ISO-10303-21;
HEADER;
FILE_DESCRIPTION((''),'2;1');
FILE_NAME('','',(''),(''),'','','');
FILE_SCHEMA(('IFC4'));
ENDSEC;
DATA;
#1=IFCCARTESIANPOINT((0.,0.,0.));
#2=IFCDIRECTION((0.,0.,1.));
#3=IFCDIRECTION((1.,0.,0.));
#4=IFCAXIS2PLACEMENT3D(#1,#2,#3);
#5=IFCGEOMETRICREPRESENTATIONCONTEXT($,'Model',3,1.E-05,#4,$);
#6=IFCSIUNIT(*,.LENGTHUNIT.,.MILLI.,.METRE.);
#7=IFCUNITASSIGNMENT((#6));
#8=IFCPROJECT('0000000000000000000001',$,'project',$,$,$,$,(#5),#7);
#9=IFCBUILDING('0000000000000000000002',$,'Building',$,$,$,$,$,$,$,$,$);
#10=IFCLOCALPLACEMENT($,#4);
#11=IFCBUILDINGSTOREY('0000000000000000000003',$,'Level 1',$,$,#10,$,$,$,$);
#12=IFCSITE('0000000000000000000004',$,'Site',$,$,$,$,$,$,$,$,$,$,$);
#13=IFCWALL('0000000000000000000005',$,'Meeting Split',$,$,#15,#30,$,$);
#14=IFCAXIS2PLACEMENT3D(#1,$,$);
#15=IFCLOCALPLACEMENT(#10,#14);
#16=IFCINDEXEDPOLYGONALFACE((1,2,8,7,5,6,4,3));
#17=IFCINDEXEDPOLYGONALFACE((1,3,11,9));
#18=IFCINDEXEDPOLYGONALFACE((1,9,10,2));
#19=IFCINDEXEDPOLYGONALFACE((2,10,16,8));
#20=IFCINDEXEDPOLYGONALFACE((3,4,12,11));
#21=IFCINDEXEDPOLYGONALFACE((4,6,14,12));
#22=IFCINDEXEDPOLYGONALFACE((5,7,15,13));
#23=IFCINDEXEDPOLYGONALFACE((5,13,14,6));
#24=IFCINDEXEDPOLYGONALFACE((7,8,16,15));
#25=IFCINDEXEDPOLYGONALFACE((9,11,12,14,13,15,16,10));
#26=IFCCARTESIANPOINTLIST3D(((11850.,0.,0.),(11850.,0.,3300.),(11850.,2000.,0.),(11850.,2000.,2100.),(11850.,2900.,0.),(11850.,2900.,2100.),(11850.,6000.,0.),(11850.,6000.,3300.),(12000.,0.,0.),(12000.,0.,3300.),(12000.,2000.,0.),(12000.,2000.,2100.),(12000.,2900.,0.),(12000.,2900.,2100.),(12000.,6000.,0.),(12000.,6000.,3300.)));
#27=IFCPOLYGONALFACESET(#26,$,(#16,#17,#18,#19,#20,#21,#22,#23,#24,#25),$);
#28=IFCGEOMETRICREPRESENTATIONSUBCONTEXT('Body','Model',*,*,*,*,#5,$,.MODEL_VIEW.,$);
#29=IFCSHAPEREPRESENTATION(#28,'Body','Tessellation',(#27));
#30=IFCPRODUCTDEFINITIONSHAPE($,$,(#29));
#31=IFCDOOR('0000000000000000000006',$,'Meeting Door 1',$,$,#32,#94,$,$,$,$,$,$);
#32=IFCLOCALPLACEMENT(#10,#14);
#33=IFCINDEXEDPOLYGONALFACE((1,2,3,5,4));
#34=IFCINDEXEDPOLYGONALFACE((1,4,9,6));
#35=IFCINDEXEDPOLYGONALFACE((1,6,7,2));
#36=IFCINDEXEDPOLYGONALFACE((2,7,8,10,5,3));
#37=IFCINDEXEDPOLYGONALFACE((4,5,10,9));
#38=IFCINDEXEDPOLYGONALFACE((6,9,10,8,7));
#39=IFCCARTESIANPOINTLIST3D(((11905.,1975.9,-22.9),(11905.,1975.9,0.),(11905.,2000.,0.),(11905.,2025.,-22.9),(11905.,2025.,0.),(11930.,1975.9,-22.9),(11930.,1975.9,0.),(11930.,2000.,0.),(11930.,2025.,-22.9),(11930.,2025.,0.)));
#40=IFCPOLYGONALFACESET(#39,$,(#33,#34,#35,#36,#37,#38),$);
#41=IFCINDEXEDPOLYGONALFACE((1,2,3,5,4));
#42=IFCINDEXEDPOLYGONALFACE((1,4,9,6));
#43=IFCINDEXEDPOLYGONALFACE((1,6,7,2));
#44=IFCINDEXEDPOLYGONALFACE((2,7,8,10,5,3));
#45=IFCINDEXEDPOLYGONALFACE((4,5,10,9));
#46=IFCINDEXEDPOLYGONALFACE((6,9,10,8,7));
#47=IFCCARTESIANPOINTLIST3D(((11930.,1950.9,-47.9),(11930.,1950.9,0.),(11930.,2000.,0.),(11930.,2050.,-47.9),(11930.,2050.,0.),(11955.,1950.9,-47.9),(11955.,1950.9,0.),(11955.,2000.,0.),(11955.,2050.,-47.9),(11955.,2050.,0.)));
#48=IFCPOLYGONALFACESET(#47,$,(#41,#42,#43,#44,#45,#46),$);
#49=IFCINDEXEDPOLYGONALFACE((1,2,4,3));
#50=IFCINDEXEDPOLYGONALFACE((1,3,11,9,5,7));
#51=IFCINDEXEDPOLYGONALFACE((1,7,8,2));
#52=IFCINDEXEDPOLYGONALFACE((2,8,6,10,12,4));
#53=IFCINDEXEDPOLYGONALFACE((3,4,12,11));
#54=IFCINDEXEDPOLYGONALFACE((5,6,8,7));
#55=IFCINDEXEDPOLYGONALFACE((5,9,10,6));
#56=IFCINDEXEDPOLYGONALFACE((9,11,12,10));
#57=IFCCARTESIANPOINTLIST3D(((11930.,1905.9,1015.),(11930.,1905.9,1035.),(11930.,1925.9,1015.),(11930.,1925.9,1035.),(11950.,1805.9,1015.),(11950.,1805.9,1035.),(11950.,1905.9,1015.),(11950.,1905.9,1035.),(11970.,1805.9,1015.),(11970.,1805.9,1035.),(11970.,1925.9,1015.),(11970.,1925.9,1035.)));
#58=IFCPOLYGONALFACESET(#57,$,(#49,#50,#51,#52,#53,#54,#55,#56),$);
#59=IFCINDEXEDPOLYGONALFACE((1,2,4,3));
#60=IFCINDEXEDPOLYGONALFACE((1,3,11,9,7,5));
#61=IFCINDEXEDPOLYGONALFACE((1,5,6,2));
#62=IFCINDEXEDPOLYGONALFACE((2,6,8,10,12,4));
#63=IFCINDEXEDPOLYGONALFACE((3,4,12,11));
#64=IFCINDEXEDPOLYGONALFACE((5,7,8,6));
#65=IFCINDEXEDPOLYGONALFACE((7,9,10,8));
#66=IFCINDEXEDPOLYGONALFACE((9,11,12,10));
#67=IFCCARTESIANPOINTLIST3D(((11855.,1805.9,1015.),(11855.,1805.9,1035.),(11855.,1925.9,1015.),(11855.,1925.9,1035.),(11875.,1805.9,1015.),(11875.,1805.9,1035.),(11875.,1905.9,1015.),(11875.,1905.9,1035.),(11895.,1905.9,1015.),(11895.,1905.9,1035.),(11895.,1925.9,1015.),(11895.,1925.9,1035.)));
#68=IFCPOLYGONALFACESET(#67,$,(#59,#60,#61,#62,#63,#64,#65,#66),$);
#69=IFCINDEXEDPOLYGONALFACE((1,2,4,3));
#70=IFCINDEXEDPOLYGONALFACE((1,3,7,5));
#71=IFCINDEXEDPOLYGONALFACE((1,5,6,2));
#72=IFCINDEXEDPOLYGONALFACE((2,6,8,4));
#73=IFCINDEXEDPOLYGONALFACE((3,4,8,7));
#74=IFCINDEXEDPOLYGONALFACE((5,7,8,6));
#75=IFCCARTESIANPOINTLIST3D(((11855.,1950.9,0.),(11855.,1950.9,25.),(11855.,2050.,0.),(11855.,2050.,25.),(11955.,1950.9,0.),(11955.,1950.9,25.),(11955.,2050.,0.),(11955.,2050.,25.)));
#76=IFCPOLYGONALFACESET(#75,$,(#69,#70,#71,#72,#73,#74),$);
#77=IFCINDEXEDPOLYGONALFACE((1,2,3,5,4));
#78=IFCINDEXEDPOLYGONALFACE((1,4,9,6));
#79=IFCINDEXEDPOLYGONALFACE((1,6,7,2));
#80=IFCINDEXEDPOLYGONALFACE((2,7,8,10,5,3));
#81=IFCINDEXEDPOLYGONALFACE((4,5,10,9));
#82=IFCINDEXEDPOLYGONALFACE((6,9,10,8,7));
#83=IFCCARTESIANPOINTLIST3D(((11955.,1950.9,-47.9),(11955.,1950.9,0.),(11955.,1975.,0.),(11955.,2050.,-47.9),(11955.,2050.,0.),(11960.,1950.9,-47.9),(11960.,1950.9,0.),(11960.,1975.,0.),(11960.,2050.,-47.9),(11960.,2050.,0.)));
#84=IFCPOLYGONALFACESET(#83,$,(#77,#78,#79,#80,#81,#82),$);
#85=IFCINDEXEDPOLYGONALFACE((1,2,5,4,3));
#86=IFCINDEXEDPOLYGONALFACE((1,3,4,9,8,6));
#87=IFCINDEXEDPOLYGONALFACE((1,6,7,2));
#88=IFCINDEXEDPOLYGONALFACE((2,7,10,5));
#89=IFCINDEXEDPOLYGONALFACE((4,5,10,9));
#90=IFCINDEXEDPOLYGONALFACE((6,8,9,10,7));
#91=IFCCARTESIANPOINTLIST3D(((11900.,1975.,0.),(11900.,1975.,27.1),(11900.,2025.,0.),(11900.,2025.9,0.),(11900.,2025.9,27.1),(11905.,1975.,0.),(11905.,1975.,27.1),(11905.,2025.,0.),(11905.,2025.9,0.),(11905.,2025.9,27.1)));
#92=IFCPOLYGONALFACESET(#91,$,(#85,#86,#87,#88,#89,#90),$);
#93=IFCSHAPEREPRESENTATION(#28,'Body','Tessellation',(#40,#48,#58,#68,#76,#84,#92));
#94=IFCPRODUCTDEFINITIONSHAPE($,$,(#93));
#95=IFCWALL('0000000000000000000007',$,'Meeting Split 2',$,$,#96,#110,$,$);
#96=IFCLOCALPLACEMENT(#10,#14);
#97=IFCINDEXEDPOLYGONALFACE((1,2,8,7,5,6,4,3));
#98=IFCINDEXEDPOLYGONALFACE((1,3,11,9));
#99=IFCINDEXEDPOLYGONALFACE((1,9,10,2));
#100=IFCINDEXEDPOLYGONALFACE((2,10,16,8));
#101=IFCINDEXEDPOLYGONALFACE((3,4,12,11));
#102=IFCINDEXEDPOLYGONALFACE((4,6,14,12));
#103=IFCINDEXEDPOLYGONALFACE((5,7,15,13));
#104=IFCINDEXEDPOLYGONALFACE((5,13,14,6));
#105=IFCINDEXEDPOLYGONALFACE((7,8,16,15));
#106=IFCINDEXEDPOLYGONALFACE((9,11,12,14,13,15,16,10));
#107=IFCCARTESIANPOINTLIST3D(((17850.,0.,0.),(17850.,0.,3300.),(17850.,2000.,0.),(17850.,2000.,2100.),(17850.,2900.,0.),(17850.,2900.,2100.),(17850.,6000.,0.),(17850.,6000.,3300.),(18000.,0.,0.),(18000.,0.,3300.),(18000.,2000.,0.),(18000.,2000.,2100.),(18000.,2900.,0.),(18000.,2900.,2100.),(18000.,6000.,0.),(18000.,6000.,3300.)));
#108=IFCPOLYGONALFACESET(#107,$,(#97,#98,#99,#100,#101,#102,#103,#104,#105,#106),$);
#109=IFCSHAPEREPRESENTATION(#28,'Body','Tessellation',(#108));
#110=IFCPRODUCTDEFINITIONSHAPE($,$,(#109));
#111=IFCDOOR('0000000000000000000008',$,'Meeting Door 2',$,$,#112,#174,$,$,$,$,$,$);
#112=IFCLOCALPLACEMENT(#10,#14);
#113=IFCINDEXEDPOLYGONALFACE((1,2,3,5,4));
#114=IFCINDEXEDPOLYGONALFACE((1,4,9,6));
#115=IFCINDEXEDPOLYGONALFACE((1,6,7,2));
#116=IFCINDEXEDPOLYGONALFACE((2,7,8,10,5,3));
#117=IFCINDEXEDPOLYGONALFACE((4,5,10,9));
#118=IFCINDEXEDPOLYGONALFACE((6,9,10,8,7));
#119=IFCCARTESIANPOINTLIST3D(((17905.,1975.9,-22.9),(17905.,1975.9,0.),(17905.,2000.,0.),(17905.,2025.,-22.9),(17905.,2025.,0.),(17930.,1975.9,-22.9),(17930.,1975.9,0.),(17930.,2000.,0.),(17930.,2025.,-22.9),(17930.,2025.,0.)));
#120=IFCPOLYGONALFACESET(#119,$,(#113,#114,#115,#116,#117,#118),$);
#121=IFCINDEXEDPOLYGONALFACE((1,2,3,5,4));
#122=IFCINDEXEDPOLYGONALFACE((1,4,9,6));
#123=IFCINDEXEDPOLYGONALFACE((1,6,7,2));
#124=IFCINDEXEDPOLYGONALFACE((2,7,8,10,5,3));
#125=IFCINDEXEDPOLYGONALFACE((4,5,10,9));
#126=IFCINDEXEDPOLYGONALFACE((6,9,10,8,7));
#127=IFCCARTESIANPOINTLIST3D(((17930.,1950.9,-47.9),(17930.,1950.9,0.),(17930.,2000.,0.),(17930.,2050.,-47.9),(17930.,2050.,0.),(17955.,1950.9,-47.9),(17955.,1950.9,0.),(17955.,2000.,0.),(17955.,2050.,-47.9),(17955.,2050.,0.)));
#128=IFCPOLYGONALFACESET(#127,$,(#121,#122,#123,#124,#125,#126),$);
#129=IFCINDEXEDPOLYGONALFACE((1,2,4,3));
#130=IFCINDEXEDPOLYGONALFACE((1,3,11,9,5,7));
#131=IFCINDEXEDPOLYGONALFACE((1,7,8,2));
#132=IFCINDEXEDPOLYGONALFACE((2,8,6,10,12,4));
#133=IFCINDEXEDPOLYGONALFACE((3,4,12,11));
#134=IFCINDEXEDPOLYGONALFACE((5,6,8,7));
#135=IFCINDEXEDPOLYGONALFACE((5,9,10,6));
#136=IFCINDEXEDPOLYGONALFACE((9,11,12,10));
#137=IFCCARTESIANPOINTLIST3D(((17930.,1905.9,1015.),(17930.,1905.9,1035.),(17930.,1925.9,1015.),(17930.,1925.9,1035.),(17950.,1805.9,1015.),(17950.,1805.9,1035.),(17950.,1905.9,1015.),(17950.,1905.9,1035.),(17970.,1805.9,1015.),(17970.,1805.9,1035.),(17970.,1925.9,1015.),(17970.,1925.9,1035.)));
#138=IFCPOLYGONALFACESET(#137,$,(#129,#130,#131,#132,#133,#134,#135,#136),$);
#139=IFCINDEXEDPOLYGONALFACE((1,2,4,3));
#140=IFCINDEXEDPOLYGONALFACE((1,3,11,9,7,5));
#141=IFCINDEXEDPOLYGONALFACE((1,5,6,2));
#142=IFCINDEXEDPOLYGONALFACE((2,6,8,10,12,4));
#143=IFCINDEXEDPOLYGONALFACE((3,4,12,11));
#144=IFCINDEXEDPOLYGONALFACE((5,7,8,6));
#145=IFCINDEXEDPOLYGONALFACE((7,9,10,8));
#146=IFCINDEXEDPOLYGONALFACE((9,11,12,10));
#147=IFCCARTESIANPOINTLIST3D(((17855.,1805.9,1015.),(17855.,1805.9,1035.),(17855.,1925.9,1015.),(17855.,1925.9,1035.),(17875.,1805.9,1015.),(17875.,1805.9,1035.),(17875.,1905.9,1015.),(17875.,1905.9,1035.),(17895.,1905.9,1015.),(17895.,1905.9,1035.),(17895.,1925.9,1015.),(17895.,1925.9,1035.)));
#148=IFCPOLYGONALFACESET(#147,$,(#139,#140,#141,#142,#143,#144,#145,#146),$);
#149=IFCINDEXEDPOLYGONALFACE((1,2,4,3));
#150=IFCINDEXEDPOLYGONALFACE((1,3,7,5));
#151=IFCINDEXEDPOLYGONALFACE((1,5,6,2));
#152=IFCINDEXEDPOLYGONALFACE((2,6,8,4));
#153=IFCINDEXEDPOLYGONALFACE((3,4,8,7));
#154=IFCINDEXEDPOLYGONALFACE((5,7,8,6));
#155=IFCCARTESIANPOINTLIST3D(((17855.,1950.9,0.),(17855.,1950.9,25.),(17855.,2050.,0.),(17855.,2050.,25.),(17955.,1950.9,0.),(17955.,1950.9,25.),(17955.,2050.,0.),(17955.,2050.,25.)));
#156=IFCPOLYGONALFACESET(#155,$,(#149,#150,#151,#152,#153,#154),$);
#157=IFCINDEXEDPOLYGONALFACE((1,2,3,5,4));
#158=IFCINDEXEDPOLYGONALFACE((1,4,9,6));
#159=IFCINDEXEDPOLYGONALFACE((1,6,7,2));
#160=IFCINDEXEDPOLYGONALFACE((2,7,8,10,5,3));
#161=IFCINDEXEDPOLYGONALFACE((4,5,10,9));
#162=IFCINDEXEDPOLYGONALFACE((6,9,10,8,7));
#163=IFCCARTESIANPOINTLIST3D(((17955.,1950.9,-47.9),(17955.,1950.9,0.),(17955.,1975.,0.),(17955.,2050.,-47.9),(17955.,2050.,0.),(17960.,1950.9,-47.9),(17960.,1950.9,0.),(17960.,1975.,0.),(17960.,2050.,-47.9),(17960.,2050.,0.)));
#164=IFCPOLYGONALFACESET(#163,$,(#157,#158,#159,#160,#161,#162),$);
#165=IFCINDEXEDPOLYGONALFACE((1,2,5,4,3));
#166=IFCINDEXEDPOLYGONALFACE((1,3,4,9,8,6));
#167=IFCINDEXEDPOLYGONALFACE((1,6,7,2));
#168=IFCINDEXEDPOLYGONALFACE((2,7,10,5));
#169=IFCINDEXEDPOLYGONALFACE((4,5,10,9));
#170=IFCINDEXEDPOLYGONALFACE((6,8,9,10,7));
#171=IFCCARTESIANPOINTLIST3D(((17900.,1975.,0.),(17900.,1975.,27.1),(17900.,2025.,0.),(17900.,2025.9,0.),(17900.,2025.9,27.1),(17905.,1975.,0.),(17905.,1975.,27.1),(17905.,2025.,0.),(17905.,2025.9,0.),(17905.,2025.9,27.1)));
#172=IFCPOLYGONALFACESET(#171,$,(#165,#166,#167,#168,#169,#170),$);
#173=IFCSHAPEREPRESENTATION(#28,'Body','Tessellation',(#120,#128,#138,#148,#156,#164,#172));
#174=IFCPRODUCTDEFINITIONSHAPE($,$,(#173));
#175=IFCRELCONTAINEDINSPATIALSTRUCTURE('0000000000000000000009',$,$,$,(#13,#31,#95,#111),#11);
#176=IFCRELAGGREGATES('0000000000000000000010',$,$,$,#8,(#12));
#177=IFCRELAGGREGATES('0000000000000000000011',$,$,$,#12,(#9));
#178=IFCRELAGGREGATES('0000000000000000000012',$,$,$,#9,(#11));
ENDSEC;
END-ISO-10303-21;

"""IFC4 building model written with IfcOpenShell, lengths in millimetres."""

from ifc_helpers import new_model, si_unit, frame, origin_with_axes, place, context, subcontext, project, spatial, line, indexed_curve, outline, extrude, element, fill, save


model = new_model("IFC4")

# Units and contexts
model_context = context("Model", 3, precision=1e-05, world=origin_with_axes())
body_context = subcontext(model_context, "Body", "Model", "MODEL_VIEW")
ifc_project = project(units=[si_unit("LENGTHUNIT", "METRE", prefix="MILLI")], contexts=[model_context])

# Site, building, storey
site = spatial("IfcSite", under=ifc_project, Name="Site")
building = spatial("IfcBuilding", under=site, Name="Building")
storey_placement = place(None, origin_with_axes())
storey = spatial("IfcBuildingStorey", under=building, at=storey_placement, Name="Level 1")

# Walls, openings, doors
wall_1_placement = place(storey_placement, frame((12000.0, 0.0, 0.0), z_axis=(0.0, 0.0, 1.0), x_axis=(0.0, 1.0, 0.0)))
wall_1 = element("IfcWall", 1, at=wall_1_placement, inside=storey, Name="Meeting Split", context=body_context, shape_type="SweptSolid", body=[
    extrude(outline(indexed_curve([(0.0, 0.0), (0.0, 150.0), (6000.0, 150.0), (6000.0, 0.0), (0.0, 0.0)], self_intersect=False)), origin_with_axes(), (0.0, 0.0, 1.0), 3300.0),
])
opening_1_placement = place(wall_1_placement, frame((2000.0, -100.0, 0.0), z_axis=(0.0, 0.0, 1.0), x_axis=(1.0, 0.0, 0.0)))
opening_1 = element("IfcOpeningElement", 2, at=opening_1_placement, cuts=wall_1, context=body_context, shape_type="SweptSolid", body=[
    extrude(outline(indexed_curve([(0.0, 0.0), (0.0, 350.0), (900.0, 350.0), (900.0, 0.0), (0.0, 0.0)], self_intersect=False)), origin_with_axes(), (0.0, 0.0, 1.0), 2100.0),
])
door_1_placement = place(opening_1_placement, frame((0.0, 145.0, 0.0), z_axis=(0.0, 0.0, 1.0), x_axis=(1.0, 0.0, 0.0)))
door_1 = element("IfcDoor", 3, at=door_1_placement, inside=storey, Name="Meeting Door 1", context=body_context, shape_type="SweptSolid", body=[
    extrude(outline(indexed_curve([(0.0, 0.0), (0.0, 2.1), (0.9, 2.1), (0.9, 0.0), (-24.1, 0.0), (-24.1, -22.9), (25.0, -22.9), (25.0, 0.0)], segments=[line(1, 2, 3, 4, 5, 6, 7, 8, 1)])), frame((0.0, 25.0, 0.0), z_axis=(0.0, -1.0, 0.0), x_axis=(1.0, 0.0, 0.0)), (0.0, 0.0, -1.0), 25.0),
    extrude(outline(indexed_curve([(0.0, 0.0), (0.0, 2.1), (0.9, 2.1), (0.9, 0.0), (-49.1, 0.0), (-49.1, -47.9), (50.0, -47.9), (50.0, 0.0)], segments=[line(1, 2, 3, 4, 5, 6, 7, 8, 1)])), frame((0.0, 0.0, 0.0), z_axis=(0.0, -1.0, 0.0), x_axis=(1.0, 0.0, 0.0)), (0.0, 0.0, -1.0), 25.0),
    extrude(outline(indexed_curve([(0.0, 0.0), (-49.1, 0.0), (-49.1, 35.0), (0.0, 35.0)], segments=[line(1, 2, 3, 4, 1)])), frame((25.0, 25.0, 25.0), z_axis=(0.0, 0.0, 1.0), x_axis=(1.0, 0.0, 0.0)), (0.0, 0.0, 1.0), -47.9),
    extrude(outline(indexed_curve([(0.0, 0.0), (0.0, -40.0), (-120.0, -40.0), (-120.0, -20.0), (-20.0, -20.0), (-20.0, 0.0)], segments=[line(1, 2, 3, 4, 5, 6, 1)])), frame((-74.1, 25.0, 1015.0), z_axis=(0.0, 0.0, 1.0), x_axis=(1.0, 0.0, 0.0)), (0.0, 0.0, 1.0), 20.0),
    extrude(outline(indexed_curve([(0.0, 0.0), (0.0, 40.0), (-120.0, 40.0), (-120.0, 20.0), (-20.0, 20.0), (-20.0, 0.0)], segments=[line(1, 2, 3, 4, 5, 6, 1)])), frame((-74.1, 60.0, 1015.0), z_axis=(0.0, 0.0, 1.0), x_axis=(1.0, 0.0, 0.0)), (0.0, 0.0, 1.0), 20.0),
    extrude(outline(indexed_curve([(0.0, 0.0), (-99.1, 0.0), (-99.1, 100.0), (0.0, 100.0)], segments=[line(1, 2, 3, 4, 1)])), frame((50.0, 0.0, 0.0), z_axis=(0.0, 0.0, 1.0), x_axis=(1.0, 0.0, 0.0)), (0.0, 0.0, 1.0), 25.0),
    extrude(outline(indexed_curve([(0.0, 0.0), (0.0, 27.1), (50.9, 27.1), (50.9, 0.0), (-24.1, 0.0), (-24.1, -47.9), (75.0, -47.9), (75.0, 0.0)], segments=[line(1, 2, 3, 4, 5, 6, 7, 8, 1)])), frame((-25.0, -5.0, 0.0), z_axis=(0.0, -1.0, 0.0), x_axis=(1.0, 0.0, 0.0)), (0.0, 0.0, -1.0), 5.0),
    extrude(outline(indexed_curve([(0.0, 0.0), (0.0, 27.1), (50.9, 27.1), (50.9, 0.0), (0.9, 0.0), (0.9, -22.9), (50.0, -22.9), (50.0, 0.0)], segments=[line(1, 2, 3, 4, 5, 6, 7, 8, 1)])), frame((-25.0, 50.0, 0.0), z_axis=(0.0, -1.0, 0.0), x_axis=(1.0, 0.0, 0.0)), (0.0, 0.0, -1.0), 5.0),
])
fill(opening_1, door_1)
wall_2_placement = place(storey_placement, frame((18000.0, 0.0, 0.0), z_axis=(0.0, 0.0, 1.0), x_axis=(0.0, 1.0, 0.0)))
wall_2 = element("IfcWall", 4, at=wall_2_placement, inside=storey, Name="Meeting Split 2", context=body_context, shape_type="SweptSolid", body=[
    extrude(outline(indexed_curve([(0.0, 0.0), (0.0, 150.0), (6000.0, 150.0), (6000.0, 0.0), (0.0, 0.0)], self_intersect=False)), origin_with_axes(), (0.0, 0.0, 1.0), 3300.0),
])
opening_2_placement = place(wall_2_placement, frame((2000.0, -100.0, 0.0), z_axis=(0.0, 0.0, 1.0), x_axis=(1.0, 0.0, 0.0)))
opening_2 = element("IfcOpeningElement", 5, at=opening_2_placement, cuts=wall_2, context=body_context, shape_type="SweptSolid", body=[
    extrude(outline(indexed_curve([(0.0, 0.0), (0.0, 350.0), (900.0, 350.0), (900.0, 0.0), (0.0, 0.0)], self_intersect=False)), origin_with_axes(), (0.0, 0.0, 1.0), 2100.0),
])
door_2_placement = place(opening_2_placement, frame((0.0, 145.0, 0.0), z_axis=(0.0, 0.0, 1.0), x_axis=(1.0, 0.0, 0.0)))
door_2 = element("IfcDoor", 6, at=door_2_placement, inside=storey, Name="Meeting Door 2", context=body_context, shape_type="SweptSolid", body=[
    extrude(outline(indexed_curve([(0.0, 0.0), (0.0, 2.1), (0.9, 2.1), (0.9, 0.0), (-24.1, 0.0), (-24.1, -22.9), (25.0, -22.9), (25.0, 0.0)], segments=[line(1, 2, 3, 4, 5, 6, 7, 8, 1)])), frame((0.0, 25.0, 0.0), z_axis=(0.0, -1.0, 0.0), x_axis=(1.0, 0.0, 0.0)), (0.0, 0.0, -1.0), 25.0),
    extrude(outline(indexed_curve([(0.0, 0.0), (0.0, 2.1), (0.9, 2.1), (0.9, 0.0), (-49.1, 0.0), (-49.1, -47.9), (50.0, -47.9), (50.0, 0.0)], segments=[line(1, 2, 3, 4, 5, 6, 7, 8, 1)])), frame((0.0, 0.0, 0.0), z_axis=(0.0, -1.0, 0.0), x_axis=(1.0, 0.0, 0.0)), (0.0, 0.0, -1.0), 25.0),
    extrude(outline(indexed_curve([(0.0, 0.0), (-49.1, 0.0), (-49.1, 35.0), (0.0, 35.0)], segments=[line(1, 2, 3, 4, 1)])), frame((25.0, 25.0, 25.0), z_axis=(0.0, 0.0, 1.0), x_axis=(1.0, 0.0, 0.0)), (0.0, 0.0, 1.0), -47.9),
    extrude(outline(indexed_curve([(0.0, 0.0), (0.0, -40.0), (-120.0, -40.0), (-120.0, -20.0), (-20.0, -20.0), (-20.0, 0.0)], segments=[line(1, 2, 3, 4, 5, 6, 1)])), frame((-74.1, 25.0, 1015.0), z_axis=(0.0, 0.0, 1.0), x_axis=(1.0, 0.0, 0.0)), (0.0, 0.0, 1.0), 20.0),
    extrude(outline(indexed_curve([(0.0, 0.0), (0.0, 40.0), (-120.0, 40.0), (-120.0, 20.0), (-20.0, 20.0), (-20.0, 0.0)], segments=[line(1, 2, 3, 4, 5, 6, 1)])), frame((-74.1, 60.0, 1015.0), z_axis=(0.0, 0.0, 1.0), x_axis=(1.0, 0.0, 0.0)), (0.0, 0.0, 1.0), 20.0),
    extrude(outline(indexed_curve([(0.0, 0.0), (-99.1, 0.0), (-99.1, 100.0), (0.0, 100.0)], segments=[line(1, 2, 3, 4, 1)])), frame((50.0, 0.0, 0.0), z_axis=(0.0, 0.0, 1.0), x_axis=(1.0, 0.0, 0.0)), (0.0, 0.0, 1.0), 25.0),
    extrude(outline(indexed_curve([(0.0, 0.0), (0.0, 27.1), (50.9, 27.1), (50.9, 0.0), (-24.1, 0.0), (-24.1, -47.9), (75.0, -47.9), (75.0, 0.0)], segments=[line(1, 2, 3, 4, 5, 6, 7, 8, 1)])), frame((-25.0, -5.0, 0.0), z_axis=(0.0, -1.0, 0.0), x_axis=(1.0, 0.0, 0.0)), (0.0, 0.0, -1.0), 5.0),
    extrude(outline(indexed_curve([(0.0, 0.0), (0.0, 27.1), (50.9, 27.1), (50.9, 0.0), (0.9, 0.0), (0.9, -22.9), (50.0, -22.9), (50.0, 0.0)], segments=[line(1, 2, 3, 4, 5, 6, 7, 8, 1)])), frame((-25.0, 50.0, 0.0), z_axis=(0.0, -1.0, 0.0), x_axis=(1.0, 0.0, 0.0)), (0.0, 0.0, -1.0), 5.0),
])
fill(opening_2, door_2)

save(model, "model.ifc")
